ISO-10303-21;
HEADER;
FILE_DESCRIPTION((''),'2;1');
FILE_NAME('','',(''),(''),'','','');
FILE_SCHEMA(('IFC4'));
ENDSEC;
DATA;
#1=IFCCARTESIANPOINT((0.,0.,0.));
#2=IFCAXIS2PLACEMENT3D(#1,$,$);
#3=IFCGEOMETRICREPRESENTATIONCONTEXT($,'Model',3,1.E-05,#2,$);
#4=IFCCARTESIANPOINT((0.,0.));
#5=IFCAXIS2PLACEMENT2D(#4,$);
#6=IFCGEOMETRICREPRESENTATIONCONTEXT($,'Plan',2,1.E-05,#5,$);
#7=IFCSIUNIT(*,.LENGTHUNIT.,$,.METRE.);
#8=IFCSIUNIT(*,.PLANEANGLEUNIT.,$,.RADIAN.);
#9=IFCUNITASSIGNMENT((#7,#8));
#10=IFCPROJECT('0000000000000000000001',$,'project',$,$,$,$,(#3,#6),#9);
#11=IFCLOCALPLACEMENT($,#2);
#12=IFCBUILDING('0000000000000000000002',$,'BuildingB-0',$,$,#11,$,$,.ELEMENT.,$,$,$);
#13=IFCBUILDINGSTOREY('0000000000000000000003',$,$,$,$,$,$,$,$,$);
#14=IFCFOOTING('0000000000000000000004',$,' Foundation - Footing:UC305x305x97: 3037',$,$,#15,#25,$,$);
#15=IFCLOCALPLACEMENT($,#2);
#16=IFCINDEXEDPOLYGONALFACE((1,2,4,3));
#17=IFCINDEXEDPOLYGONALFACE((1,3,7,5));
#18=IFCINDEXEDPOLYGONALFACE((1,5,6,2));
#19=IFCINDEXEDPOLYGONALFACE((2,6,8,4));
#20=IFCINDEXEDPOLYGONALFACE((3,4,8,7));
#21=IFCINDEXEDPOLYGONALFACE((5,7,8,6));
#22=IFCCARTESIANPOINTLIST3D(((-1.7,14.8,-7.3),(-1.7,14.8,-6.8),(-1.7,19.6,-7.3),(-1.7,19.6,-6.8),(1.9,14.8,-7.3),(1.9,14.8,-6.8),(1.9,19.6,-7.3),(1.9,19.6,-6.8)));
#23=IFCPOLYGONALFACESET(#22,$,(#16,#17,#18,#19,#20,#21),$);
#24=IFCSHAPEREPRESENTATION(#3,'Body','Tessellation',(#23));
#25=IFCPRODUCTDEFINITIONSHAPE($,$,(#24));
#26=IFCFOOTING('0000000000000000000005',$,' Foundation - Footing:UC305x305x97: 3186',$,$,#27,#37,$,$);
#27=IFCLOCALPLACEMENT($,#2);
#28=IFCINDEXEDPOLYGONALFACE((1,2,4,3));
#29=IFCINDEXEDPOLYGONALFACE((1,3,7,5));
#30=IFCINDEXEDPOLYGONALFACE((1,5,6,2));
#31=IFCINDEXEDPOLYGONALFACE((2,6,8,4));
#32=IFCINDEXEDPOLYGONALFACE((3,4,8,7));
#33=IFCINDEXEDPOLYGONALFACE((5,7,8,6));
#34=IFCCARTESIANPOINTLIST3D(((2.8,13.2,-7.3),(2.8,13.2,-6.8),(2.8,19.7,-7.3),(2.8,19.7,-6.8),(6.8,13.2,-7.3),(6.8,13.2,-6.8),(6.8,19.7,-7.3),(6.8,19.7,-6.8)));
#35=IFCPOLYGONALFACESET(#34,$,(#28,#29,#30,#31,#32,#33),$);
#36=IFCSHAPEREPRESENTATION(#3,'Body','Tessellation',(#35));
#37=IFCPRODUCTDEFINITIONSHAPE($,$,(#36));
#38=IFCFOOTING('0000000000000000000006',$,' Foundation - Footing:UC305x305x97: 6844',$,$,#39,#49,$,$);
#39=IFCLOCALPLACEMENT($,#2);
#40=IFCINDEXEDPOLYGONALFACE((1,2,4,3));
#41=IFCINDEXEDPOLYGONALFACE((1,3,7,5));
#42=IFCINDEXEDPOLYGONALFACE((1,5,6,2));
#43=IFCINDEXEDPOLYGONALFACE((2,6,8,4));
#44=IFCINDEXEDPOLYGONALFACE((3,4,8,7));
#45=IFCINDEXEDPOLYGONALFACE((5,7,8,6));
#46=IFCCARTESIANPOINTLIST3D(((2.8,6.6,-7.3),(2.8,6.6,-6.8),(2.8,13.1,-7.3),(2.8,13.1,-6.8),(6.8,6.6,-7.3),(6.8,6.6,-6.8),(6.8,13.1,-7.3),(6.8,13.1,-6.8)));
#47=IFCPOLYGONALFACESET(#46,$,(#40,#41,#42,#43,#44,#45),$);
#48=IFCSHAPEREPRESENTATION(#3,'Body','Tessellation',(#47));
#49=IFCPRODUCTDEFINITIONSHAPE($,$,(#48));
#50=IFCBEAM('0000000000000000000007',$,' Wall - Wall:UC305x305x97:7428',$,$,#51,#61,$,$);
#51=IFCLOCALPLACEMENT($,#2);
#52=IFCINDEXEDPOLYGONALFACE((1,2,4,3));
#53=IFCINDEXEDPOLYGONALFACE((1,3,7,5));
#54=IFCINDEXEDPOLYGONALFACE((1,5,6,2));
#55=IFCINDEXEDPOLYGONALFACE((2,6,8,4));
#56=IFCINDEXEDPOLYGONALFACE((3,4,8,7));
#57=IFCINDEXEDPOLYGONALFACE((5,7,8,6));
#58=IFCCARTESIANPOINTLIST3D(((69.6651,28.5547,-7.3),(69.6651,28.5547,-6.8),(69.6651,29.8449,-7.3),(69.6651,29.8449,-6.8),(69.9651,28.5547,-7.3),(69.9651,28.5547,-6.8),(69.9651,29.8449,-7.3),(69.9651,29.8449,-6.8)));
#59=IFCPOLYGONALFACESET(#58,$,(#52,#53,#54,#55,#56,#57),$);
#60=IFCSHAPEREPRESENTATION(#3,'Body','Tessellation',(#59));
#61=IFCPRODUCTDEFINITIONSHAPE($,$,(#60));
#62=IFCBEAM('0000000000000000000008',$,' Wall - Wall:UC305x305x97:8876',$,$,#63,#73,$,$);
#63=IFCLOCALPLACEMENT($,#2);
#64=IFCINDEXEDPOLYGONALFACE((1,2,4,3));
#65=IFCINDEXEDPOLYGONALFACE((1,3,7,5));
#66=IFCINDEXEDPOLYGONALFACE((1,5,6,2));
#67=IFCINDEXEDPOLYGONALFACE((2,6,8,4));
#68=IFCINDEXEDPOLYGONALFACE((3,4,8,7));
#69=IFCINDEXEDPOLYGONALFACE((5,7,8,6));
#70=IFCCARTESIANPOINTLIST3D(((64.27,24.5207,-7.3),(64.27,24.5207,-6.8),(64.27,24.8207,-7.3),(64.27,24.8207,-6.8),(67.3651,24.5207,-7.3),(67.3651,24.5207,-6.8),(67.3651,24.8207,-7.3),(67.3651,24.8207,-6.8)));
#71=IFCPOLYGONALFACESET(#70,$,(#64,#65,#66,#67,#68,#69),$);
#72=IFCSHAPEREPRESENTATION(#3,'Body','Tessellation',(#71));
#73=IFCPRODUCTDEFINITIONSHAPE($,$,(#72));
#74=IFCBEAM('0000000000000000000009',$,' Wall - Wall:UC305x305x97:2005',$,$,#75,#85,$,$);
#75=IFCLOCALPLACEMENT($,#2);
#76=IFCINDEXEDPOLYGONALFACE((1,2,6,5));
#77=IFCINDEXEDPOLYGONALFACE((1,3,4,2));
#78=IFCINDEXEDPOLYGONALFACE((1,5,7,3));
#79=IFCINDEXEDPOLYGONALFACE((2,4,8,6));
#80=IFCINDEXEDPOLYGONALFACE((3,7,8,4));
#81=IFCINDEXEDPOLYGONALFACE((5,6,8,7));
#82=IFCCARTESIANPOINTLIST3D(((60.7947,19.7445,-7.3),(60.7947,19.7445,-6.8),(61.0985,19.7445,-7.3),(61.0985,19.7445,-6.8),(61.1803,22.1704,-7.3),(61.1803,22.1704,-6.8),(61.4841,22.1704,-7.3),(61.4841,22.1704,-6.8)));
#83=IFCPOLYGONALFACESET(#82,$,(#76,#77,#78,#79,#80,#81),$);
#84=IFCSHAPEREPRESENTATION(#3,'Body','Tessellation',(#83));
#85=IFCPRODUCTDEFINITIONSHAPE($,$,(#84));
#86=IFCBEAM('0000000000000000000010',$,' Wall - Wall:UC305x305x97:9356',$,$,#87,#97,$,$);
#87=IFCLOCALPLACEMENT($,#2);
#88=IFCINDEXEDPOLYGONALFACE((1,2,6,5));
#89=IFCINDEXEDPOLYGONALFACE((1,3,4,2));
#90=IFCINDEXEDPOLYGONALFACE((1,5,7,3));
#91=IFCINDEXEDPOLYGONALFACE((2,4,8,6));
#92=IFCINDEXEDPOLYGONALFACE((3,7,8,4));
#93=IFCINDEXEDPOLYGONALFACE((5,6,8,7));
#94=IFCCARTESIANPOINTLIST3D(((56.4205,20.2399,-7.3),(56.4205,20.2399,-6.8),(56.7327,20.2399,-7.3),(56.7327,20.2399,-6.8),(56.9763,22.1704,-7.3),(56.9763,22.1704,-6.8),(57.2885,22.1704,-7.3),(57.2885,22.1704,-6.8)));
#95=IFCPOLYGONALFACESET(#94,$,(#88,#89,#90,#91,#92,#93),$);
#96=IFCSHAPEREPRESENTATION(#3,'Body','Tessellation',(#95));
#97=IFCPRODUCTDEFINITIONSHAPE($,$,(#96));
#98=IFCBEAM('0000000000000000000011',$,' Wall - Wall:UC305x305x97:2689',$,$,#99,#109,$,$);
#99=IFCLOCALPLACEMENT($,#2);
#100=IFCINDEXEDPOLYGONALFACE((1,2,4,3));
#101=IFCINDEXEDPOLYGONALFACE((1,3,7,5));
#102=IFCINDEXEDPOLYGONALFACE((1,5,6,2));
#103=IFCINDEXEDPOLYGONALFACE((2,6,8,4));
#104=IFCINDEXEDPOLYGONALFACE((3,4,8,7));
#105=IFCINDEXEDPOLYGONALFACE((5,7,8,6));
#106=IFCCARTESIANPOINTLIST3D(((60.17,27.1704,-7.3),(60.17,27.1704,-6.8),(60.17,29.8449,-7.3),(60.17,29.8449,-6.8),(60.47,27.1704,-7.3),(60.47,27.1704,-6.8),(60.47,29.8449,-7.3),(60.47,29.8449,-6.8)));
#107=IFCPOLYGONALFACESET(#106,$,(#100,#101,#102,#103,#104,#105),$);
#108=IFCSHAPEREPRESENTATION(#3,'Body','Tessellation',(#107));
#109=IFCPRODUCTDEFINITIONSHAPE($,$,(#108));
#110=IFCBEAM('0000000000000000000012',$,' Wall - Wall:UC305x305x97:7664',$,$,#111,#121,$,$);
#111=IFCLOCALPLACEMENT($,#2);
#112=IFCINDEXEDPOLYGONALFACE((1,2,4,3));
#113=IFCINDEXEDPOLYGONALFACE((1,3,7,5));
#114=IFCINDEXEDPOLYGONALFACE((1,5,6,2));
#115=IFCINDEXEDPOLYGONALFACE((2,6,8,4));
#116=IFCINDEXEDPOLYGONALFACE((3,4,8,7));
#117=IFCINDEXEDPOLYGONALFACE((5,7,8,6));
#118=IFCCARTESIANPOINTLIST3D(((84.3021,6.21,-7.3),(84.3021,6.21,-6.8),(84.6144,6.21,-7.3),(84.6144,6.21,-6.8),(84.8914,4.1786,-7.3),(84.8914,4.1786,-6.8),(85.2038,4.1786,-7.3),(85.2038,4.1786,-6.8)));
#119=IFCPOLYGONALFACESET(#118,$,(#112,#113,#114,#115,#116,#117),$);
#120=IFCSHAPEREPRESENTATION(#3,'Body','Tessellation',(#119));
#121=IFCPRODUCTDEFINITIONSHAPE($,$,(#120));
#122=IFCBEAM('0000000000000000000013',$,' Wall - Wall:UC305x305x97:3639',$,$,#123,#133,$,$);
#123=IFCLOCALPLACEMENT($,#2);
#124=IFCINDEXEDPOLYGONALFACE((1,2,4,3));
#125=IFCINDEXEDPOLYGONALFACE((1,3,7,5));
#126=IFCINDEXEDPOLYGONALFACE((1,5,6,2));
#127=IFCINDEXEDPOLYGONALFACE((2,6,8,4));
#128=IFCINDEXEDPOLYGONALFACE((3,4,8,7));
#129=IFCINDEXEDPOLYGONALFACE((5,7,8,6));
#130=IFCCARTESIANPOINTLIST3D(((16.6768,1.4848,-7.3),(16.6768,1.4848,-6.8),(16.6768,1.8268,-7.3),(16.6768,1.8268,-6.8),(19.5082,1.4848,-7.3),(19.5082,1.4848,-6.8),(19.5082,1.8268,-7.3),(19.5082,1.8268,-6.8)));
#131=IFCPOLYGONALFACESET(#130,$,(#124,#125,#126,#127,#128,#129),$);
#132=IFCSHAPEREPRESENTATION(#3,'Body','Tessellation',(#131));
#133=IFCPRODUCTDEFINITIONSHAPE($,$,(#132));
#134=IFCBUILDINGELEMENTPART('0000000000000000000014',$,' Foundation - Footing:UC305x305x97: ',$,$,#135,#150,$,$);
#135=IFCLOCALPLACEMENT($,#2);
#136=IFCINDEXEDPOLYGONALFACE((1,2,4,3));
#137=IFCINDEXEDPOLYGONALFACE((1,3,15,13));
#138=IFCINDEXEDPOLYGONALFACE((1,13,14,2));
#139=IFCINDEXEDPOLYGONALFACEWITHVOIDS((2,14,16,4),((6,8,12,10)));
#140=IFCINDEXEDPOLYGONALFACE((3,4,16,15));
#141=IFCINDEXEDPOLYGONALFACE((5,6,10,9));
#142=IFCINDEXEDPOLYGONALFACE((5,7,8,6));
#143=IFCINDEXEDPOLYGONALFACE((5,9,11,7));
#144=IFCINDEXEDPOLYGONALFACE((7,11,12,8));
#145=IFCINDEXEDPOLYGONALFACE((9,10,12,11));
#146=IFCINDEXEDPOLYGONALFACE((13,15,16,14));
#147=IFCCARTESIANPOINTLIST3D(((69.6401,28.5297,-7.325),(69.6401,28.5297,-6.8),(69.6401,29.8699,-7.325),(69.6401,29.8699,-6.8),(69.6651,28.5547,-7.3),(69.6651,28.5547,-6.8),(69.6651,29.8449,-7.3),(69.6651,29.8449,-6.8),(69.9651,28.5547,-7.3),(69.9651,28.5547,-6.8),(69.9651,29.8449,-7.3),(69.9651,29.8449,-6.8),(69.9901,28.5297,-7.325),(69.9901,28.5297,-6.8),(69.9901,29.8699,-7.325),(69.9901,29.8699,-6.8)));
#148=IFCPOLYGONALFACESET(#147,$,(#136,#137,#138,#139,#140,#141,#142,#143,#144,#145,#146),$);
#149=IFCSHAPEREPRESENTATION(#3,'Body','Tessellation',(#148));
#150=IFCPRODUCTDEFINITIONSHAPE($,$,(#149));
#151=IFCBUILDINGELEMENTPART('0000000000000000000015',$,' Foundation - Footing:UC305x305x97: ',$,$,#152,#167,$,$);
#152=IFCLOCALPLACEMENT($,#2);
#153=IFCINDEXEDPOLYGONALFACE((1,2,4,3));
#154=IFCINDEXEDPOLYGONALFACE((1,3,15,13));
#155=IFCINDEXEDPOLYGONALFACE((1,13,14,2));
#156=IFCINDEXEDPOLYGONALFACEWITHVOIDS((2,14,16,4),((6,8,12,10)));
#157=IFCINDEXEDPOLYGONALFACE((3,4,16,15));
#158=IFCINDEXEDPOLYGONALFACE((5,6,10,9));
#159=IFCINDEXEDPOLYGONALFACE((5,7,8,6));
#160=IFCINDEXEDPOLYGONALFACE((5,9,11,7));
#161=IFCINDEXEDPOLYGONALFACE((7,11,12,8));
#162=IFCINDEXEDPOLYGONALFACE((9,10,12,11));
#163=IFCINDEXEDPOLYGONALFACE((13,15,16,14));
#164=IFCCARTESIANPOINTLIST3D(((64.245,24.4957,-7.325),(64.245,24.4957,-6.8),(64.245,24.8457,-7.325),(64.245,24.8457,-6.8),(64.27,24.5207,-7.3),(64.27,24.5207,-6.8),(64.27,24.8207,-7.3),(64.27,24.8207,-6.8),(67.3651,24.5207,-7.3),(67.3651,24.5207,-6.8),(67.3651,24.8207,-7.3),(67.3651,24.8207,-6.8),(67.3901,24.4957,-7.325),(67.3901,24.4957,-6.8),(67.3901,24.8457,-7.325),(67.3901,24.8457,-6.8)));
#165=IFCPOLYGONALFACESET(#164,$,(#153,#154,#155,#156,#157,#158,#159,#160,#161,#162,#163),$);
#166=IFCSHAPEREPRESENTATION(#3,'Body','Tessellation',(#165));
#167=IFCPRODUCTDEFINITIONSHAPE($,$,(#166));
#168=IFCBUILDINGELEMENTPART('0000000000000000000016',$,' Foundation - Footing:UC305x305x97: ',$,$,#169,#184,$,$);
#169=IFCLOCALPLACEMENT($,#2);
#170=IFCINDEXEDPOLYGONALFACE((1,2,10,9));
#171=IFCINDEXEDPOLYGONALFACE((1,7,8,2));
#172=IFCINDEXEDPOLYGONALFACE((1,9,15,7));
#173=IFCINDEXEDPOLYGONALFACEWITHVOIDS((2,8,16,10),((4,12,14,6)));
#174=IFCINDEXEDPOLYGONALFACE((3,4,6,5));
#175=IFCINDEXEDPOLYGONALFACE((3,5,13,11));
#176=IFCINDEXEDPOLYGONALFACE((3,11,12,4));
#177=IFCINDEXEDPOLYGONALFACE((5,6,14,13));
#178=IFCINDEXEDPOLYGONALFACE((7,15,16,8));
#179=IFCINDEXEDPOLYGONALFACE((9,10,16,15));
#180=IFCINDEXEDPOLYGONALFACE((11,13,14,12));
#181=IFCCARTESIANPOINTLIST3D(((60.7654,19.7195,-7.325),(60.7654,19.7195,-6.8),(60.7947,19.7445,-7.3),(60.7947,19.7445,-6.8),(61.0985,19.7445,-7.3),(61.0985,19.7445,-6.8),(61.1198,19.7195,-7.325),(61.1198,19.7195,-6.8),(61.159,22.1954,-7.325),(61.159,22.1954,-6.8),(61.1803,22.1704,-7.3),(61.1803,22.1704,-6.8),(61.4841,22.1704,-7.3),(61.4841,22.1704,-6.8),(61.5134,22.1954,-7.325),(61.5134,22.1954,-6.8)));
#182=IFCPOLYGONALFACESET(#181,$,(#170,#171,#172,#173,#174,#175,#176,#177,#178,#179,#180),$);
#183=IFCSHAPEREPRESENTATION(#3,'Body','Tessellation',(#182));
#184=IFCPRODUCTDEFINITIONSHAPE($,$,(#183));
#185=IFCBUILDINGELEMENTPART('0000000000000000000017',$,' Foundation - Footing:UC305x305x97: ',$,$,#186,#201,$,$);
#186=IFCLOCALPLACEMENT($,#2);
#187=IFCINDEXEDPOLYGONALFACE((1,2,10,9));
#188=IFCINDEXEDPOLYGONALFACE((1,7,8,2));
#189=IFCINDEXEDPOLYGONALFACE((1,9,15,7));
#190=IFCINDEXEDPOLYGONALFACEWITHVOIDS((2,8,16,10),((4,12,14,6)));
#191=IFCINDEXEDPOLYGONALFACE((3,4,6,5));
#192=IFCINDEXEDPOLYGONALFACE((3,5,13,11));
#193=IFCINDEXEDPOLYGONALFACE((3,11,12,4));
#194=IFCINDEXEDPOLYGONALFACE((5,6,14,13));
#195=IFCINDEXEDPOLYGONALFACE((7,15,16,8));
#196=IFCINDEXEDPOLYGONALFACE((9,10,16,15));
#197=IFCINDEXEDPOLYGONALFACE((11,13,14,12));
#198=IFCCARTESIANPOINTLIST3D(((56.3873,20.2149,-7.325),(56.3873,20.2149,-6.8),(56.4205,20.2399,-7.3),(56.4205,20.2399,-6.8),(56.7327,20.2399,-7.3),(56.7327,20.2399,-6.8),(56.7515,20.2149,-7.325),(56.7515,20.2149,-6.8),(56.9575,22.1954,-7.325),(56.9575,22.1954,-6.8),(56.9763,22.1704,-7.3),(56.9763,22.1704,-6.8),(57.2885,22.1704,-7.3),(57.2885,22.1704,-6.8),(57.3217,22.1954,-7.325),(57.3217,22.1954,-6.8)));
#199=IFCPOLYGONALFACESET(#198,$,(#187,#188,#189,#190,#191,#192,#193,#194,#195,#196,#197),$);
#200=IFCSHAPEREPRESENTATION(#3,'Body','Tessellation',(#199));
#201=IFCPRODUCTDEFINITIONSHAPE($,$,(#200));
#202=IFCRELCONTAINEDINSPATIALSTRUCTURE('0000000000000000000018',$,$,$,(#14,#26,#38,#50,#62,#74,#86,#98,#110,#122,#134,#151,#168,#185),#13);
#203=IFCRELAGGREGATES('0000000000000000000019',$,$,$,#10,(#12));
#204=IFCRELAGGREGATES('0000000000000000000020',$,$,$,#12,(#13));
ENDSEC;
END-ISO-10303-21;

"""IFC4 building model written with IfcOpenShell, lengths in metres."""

from ifc_helpers import new_model, si_unit, origin, origin_2d, place, context, project, spatial, polyline, outline, extrude, element, save


model = new_model("IFC4")

# Units and contexts
model_context = context("Model", 3, precision=1e-05, world=origin())
plan_context = context("Plan", 2, precision=1e-05, world=origin_2d())
ifc_project = project(units=[si_unit("LENGTHUNIT", "METRE"), si_unit("PLANEANGLEUNIT", "RADIAN")], contexts=[model_context, plan_context])

# Building, storey
building_placement = place(None, origin())
building = spatial("IfcBuilding", under=ifc_project, at=building_placement, Name="BuildingB-0", CompositionType="ELEMENT")
storey = spatial("IfcBuildingStorey", under=building)

# Footings
element("IfcFooting", 1, inside=storey, Name=" Foundation - Footing:UC305x305x97: 3037", context=model_context, shape_type="SweptSolid", body=[
    extrude(outline(polyline([(1.9, 19.6, -7.3), (-1.7, 19.6, -7.3), (-1.7, 14.8, -7.3), (1.9, 14.8, -7.3), (1.9, 19.6, -7.3)])), None, (0.0, 0.0, 1.0), 0.5),
])
element("IfcFooting", 2, inside=storey, Name=" Foundation - Footing:UC305x305x97: 3186", context=model_context, shape_type="SweptSolid", body=[
    extrude(outline(polyline([(6.8, 19.7, -7.3), (2.8, 19.7, -7.3), (2.8, 13.2, -7.3), (6.8, 13.2, -7.3), (6.8, 19.7, -7.3)])), None, (0.0, 0.0, 1.0), 0.5),
])
element("IfcFooting", 3, inside=storey, Name=" Foundation - Footing:UC305x305x97: 6844", context=model_context, shape_type="SweptSolid", body=[
    extrude(outline(polyline([(6.8, 13.1, -7.3), (2.8, 13.1, -7.3), (2.8, 6.6, -7.3), (6.8, 6.6, -7.3), (6.8, 13.1, -7.3)])), None, (0.0, 0.0, 1.0), 0.5),
])

# Beams
element("IfcBeam", 4, inside=storey, Name=" Wall - Wall:UC305x305x97:7428", context=model_context, shape_type="SweptSolid", body=[
    extrude(outline(polyline([(69.9651, 28.5547, -7.3), (69.6651, 28.5547, -7.3), (69.6651, 29.8449, -7.3), (69.9651, 29.8449, -7.3), (69.9651, 28.5547, -7.3)])), None, (0.0, 0.0, 1.0), 0.5),
])
element("IfcBeam", 5, inside=storey, Name=" Wall - Wall:UC305x305x97:8876", context=model_context, shape_type="SweptSolid", body=[
    extrude(outline(polyline([(67.3651, 24.5207, -7.3), (67.3651, 24.8207, -7.3), (64.27, 24.8207, -7.3), (64.27, 24.5207, -7.3), (67.3651, 24.5207, -7.3)])), None, (0.0, 0.0, 1.0), 0.5),
])
element("IfcBeam", 6, inside=storey, Name=" Wall - Wall:UC305x305x97:2005", context=model_context, shape_type="SweptSolid", body=[
    extrude(outline(polyline([(61.0985, 19.7445, -7.3), (60.7947, 19.7445, -7.3), (61.1803, 22.1704, -7.3), (61.4841, 22.1704, -7.3), (61.0985, 19.7445, -7.3)])), None, (0.0, 0.0, 1.0), 0.5),
])
element("IfcBeam", 7, inside=storey, Name=" Wall - Wall:UC305x305x97:9356", context=model_context, shape_type="SweptSolid", body=[
    extrude(outline(polyline([(56.7327, 20.2399, -7.3), (56.4205, 20.2399, -7.3), (56.9763, 22.1704, -7.3), (57.2885, 22.1704, -7.3), (56.7327, 20.2399, -7.3)])), None, (0.0, 0.0, 1.0), 0.5),
])
element("IfcBeam", 8, inside=storey, Name=" Wall - Wall:UC305x305x97:2689", context=model_context, shape_type="SweptSolid", body=[
    extrude(outline(polyline([(60.47, 27.1704, -7.3), (60.17, 27.1704, -7.3), (60.17, 29.8449, -7.3), (60.47, 29.8449, -7.3), (60.47, 27.1704, -7.3)])), None, (0.0, 0.0, 1.0), 0.5),
])
element("IfcBeam", 9, inside=storey, Name=" Wall - Wall:UC305x305x97:7664", context=model_context, shape_type="SweptSolid", body=[
    extrude(outline(polyline([(84.8914, 4.1786, -7.3), (85.2038, 4.1786, -7.3), (84.6144, 6.21, -7.3), (84.3021, 6.21, -7.3), (84.8914, 4.1786, -7.3)])), None, (0.0, 0.0, 1.0), 0.5),
])
element("IfcBeam", 10, inside=storey, Name=" Wall - Wall:UC305x305x97:3639", context=model_context, shape_type="SweptSolid", body=[
    extrude(outline(polyline([(16.6768, 1.4848, -7.3), (19.5082, 1.4848, -7.3), (19.5082, 1.8268, -7.3), (16.6768, 1.8268, -7.3), (16.6768, 1.4848, -7.3)])), None, (0.0, 0.0, 1.0), 0.5),
])

# Building element parts, openings
building_element_part_1 = element("IfcBuildingElementPart", 11, inside=storey, Name=" Foundation - Footing:UC305x305x97: ", context=model_context, shape_type="SweptSolid", body=[
    extrude(outline(polyline([(69.9901, 28.5297, -7.325), (69.6401, 28.5297, -7.325), (69.6401, 29.8699, -7.325), (69.9901, 29.8699, -7.325), (69.9901, 28.5297, -7.325)])), None, (0.0, 0.0, 1.0), 0.525),
])
element("IfcOpeningElement", 12, inside=storey, cuts=building_element_part_1, context=model_context, shape_type="SweptSolid", body=[
    extrude(outline(polyline([(69.9651, 28.5547, -7.3), (69.6651, 28.5547, -7.3), (69.6651, 29.8449, -7.3), (69.9651, 29.8449, -7.3), (69.9651, 28.5547, -7.3)])), None, (0.0, 0.0, 1.0), 0.5),
])
building_element_part_2 = element("IfcBuildingElementPart", 13, inside=storey, Name=" Foundation - Footing:UC305x305x97: ", context=model_context, shape_type="SweptSolid", body=[
    extrude(outline(polyline([(67.3901, 24.4957, -7.325), (67.3901, 24.8457, -7.325), (64.245, 24.8457, -7.325), (64.245, 24.4957, -7.325), (67.3901, 24.4957, -7.325)])), None, (0.0, 0.0, 1.0), 0.525),
])
element("IfcOpeningElement", 14, inside=storey, cuts=building_element_part_2, context=model_context, shape_type="SweptSolid", body=[
    extrude(outline(polyline([(67.3651, 24.5207, -7.3), (67.3651, 24.8207, -7.3), (64.27, 24.8207, -7.3), (64.27, 24.5207, -7.3), (67.3651, 24.5207, -7.3)])), None, (0.0, 0.0, 1.0), 0.5),
])
building_element_part_3 = element("IfcBuildingElementPart", 15, inside=storey, Name=" Foundation - Footing:UC305x305x97: ", context=model_context, shape_type="SweptSolid", body=[
    extrude(outline(polyline([(61.1198, 19.7195, -7.325), (60.7654, 19.7195, -7.325), (61.159, 22.1954, -7.325), (61.5134, 22.1954, -7.325), (61.1198, 19.7195, -7.325)])), None, (0.0, 0.0, 1.0), 0.525),
])
element("IfcOpeningElement", 16, inside=storey, cuts=building_element_part_3, context=model_context, shape_type="SweptSolid", body=[
    extrude(outline(polyline([(61.0985, 19.7445, -7.3), (60.7947, 19.7445, -7.3), (61.1803, 22.1704, -7.3), (61.4841, 22.1704, -7.3), (61.0985, 19.7445, -7.3)])), None, (0.0, 0.0, 1.0), 0.5),
])
building_element_part_4 = element("IfcBuildingElementPart", 17, inside=storey, Name=" Foundation - Footing:UC305x305x97: ", context=model_context, shape_type="SweptSolid", body=[
    extrude(outline(polyline([(56.7515, 20.2149, -7.325), (56.3873, 20.2149, -7.325), (56.9575, 22.1954, -7.325), (57.3217, 22.1954, -7.325), (56.7515, 20.2149, -7.325)])), None, (0.0, 0.0, 1.0), 0.525),
])
element("IfcOpeningElement", 18, inside=storey, cuts=building_element_part_4, context=model_context, shape_type="SweptSolid", body=[
    extrude(outline(polyline([(56.7327, 20.2399, -7.3), (56.4205, 20.2399, -7.3), (56.9763, 22.1704, -7.3), (57.2885, 22.1704, -7.3), (56.7327, 20.2399, -7.3)])), None, (0.0, 0.0, 1.0), 0.5),
])

save(model, "model.ifc")
